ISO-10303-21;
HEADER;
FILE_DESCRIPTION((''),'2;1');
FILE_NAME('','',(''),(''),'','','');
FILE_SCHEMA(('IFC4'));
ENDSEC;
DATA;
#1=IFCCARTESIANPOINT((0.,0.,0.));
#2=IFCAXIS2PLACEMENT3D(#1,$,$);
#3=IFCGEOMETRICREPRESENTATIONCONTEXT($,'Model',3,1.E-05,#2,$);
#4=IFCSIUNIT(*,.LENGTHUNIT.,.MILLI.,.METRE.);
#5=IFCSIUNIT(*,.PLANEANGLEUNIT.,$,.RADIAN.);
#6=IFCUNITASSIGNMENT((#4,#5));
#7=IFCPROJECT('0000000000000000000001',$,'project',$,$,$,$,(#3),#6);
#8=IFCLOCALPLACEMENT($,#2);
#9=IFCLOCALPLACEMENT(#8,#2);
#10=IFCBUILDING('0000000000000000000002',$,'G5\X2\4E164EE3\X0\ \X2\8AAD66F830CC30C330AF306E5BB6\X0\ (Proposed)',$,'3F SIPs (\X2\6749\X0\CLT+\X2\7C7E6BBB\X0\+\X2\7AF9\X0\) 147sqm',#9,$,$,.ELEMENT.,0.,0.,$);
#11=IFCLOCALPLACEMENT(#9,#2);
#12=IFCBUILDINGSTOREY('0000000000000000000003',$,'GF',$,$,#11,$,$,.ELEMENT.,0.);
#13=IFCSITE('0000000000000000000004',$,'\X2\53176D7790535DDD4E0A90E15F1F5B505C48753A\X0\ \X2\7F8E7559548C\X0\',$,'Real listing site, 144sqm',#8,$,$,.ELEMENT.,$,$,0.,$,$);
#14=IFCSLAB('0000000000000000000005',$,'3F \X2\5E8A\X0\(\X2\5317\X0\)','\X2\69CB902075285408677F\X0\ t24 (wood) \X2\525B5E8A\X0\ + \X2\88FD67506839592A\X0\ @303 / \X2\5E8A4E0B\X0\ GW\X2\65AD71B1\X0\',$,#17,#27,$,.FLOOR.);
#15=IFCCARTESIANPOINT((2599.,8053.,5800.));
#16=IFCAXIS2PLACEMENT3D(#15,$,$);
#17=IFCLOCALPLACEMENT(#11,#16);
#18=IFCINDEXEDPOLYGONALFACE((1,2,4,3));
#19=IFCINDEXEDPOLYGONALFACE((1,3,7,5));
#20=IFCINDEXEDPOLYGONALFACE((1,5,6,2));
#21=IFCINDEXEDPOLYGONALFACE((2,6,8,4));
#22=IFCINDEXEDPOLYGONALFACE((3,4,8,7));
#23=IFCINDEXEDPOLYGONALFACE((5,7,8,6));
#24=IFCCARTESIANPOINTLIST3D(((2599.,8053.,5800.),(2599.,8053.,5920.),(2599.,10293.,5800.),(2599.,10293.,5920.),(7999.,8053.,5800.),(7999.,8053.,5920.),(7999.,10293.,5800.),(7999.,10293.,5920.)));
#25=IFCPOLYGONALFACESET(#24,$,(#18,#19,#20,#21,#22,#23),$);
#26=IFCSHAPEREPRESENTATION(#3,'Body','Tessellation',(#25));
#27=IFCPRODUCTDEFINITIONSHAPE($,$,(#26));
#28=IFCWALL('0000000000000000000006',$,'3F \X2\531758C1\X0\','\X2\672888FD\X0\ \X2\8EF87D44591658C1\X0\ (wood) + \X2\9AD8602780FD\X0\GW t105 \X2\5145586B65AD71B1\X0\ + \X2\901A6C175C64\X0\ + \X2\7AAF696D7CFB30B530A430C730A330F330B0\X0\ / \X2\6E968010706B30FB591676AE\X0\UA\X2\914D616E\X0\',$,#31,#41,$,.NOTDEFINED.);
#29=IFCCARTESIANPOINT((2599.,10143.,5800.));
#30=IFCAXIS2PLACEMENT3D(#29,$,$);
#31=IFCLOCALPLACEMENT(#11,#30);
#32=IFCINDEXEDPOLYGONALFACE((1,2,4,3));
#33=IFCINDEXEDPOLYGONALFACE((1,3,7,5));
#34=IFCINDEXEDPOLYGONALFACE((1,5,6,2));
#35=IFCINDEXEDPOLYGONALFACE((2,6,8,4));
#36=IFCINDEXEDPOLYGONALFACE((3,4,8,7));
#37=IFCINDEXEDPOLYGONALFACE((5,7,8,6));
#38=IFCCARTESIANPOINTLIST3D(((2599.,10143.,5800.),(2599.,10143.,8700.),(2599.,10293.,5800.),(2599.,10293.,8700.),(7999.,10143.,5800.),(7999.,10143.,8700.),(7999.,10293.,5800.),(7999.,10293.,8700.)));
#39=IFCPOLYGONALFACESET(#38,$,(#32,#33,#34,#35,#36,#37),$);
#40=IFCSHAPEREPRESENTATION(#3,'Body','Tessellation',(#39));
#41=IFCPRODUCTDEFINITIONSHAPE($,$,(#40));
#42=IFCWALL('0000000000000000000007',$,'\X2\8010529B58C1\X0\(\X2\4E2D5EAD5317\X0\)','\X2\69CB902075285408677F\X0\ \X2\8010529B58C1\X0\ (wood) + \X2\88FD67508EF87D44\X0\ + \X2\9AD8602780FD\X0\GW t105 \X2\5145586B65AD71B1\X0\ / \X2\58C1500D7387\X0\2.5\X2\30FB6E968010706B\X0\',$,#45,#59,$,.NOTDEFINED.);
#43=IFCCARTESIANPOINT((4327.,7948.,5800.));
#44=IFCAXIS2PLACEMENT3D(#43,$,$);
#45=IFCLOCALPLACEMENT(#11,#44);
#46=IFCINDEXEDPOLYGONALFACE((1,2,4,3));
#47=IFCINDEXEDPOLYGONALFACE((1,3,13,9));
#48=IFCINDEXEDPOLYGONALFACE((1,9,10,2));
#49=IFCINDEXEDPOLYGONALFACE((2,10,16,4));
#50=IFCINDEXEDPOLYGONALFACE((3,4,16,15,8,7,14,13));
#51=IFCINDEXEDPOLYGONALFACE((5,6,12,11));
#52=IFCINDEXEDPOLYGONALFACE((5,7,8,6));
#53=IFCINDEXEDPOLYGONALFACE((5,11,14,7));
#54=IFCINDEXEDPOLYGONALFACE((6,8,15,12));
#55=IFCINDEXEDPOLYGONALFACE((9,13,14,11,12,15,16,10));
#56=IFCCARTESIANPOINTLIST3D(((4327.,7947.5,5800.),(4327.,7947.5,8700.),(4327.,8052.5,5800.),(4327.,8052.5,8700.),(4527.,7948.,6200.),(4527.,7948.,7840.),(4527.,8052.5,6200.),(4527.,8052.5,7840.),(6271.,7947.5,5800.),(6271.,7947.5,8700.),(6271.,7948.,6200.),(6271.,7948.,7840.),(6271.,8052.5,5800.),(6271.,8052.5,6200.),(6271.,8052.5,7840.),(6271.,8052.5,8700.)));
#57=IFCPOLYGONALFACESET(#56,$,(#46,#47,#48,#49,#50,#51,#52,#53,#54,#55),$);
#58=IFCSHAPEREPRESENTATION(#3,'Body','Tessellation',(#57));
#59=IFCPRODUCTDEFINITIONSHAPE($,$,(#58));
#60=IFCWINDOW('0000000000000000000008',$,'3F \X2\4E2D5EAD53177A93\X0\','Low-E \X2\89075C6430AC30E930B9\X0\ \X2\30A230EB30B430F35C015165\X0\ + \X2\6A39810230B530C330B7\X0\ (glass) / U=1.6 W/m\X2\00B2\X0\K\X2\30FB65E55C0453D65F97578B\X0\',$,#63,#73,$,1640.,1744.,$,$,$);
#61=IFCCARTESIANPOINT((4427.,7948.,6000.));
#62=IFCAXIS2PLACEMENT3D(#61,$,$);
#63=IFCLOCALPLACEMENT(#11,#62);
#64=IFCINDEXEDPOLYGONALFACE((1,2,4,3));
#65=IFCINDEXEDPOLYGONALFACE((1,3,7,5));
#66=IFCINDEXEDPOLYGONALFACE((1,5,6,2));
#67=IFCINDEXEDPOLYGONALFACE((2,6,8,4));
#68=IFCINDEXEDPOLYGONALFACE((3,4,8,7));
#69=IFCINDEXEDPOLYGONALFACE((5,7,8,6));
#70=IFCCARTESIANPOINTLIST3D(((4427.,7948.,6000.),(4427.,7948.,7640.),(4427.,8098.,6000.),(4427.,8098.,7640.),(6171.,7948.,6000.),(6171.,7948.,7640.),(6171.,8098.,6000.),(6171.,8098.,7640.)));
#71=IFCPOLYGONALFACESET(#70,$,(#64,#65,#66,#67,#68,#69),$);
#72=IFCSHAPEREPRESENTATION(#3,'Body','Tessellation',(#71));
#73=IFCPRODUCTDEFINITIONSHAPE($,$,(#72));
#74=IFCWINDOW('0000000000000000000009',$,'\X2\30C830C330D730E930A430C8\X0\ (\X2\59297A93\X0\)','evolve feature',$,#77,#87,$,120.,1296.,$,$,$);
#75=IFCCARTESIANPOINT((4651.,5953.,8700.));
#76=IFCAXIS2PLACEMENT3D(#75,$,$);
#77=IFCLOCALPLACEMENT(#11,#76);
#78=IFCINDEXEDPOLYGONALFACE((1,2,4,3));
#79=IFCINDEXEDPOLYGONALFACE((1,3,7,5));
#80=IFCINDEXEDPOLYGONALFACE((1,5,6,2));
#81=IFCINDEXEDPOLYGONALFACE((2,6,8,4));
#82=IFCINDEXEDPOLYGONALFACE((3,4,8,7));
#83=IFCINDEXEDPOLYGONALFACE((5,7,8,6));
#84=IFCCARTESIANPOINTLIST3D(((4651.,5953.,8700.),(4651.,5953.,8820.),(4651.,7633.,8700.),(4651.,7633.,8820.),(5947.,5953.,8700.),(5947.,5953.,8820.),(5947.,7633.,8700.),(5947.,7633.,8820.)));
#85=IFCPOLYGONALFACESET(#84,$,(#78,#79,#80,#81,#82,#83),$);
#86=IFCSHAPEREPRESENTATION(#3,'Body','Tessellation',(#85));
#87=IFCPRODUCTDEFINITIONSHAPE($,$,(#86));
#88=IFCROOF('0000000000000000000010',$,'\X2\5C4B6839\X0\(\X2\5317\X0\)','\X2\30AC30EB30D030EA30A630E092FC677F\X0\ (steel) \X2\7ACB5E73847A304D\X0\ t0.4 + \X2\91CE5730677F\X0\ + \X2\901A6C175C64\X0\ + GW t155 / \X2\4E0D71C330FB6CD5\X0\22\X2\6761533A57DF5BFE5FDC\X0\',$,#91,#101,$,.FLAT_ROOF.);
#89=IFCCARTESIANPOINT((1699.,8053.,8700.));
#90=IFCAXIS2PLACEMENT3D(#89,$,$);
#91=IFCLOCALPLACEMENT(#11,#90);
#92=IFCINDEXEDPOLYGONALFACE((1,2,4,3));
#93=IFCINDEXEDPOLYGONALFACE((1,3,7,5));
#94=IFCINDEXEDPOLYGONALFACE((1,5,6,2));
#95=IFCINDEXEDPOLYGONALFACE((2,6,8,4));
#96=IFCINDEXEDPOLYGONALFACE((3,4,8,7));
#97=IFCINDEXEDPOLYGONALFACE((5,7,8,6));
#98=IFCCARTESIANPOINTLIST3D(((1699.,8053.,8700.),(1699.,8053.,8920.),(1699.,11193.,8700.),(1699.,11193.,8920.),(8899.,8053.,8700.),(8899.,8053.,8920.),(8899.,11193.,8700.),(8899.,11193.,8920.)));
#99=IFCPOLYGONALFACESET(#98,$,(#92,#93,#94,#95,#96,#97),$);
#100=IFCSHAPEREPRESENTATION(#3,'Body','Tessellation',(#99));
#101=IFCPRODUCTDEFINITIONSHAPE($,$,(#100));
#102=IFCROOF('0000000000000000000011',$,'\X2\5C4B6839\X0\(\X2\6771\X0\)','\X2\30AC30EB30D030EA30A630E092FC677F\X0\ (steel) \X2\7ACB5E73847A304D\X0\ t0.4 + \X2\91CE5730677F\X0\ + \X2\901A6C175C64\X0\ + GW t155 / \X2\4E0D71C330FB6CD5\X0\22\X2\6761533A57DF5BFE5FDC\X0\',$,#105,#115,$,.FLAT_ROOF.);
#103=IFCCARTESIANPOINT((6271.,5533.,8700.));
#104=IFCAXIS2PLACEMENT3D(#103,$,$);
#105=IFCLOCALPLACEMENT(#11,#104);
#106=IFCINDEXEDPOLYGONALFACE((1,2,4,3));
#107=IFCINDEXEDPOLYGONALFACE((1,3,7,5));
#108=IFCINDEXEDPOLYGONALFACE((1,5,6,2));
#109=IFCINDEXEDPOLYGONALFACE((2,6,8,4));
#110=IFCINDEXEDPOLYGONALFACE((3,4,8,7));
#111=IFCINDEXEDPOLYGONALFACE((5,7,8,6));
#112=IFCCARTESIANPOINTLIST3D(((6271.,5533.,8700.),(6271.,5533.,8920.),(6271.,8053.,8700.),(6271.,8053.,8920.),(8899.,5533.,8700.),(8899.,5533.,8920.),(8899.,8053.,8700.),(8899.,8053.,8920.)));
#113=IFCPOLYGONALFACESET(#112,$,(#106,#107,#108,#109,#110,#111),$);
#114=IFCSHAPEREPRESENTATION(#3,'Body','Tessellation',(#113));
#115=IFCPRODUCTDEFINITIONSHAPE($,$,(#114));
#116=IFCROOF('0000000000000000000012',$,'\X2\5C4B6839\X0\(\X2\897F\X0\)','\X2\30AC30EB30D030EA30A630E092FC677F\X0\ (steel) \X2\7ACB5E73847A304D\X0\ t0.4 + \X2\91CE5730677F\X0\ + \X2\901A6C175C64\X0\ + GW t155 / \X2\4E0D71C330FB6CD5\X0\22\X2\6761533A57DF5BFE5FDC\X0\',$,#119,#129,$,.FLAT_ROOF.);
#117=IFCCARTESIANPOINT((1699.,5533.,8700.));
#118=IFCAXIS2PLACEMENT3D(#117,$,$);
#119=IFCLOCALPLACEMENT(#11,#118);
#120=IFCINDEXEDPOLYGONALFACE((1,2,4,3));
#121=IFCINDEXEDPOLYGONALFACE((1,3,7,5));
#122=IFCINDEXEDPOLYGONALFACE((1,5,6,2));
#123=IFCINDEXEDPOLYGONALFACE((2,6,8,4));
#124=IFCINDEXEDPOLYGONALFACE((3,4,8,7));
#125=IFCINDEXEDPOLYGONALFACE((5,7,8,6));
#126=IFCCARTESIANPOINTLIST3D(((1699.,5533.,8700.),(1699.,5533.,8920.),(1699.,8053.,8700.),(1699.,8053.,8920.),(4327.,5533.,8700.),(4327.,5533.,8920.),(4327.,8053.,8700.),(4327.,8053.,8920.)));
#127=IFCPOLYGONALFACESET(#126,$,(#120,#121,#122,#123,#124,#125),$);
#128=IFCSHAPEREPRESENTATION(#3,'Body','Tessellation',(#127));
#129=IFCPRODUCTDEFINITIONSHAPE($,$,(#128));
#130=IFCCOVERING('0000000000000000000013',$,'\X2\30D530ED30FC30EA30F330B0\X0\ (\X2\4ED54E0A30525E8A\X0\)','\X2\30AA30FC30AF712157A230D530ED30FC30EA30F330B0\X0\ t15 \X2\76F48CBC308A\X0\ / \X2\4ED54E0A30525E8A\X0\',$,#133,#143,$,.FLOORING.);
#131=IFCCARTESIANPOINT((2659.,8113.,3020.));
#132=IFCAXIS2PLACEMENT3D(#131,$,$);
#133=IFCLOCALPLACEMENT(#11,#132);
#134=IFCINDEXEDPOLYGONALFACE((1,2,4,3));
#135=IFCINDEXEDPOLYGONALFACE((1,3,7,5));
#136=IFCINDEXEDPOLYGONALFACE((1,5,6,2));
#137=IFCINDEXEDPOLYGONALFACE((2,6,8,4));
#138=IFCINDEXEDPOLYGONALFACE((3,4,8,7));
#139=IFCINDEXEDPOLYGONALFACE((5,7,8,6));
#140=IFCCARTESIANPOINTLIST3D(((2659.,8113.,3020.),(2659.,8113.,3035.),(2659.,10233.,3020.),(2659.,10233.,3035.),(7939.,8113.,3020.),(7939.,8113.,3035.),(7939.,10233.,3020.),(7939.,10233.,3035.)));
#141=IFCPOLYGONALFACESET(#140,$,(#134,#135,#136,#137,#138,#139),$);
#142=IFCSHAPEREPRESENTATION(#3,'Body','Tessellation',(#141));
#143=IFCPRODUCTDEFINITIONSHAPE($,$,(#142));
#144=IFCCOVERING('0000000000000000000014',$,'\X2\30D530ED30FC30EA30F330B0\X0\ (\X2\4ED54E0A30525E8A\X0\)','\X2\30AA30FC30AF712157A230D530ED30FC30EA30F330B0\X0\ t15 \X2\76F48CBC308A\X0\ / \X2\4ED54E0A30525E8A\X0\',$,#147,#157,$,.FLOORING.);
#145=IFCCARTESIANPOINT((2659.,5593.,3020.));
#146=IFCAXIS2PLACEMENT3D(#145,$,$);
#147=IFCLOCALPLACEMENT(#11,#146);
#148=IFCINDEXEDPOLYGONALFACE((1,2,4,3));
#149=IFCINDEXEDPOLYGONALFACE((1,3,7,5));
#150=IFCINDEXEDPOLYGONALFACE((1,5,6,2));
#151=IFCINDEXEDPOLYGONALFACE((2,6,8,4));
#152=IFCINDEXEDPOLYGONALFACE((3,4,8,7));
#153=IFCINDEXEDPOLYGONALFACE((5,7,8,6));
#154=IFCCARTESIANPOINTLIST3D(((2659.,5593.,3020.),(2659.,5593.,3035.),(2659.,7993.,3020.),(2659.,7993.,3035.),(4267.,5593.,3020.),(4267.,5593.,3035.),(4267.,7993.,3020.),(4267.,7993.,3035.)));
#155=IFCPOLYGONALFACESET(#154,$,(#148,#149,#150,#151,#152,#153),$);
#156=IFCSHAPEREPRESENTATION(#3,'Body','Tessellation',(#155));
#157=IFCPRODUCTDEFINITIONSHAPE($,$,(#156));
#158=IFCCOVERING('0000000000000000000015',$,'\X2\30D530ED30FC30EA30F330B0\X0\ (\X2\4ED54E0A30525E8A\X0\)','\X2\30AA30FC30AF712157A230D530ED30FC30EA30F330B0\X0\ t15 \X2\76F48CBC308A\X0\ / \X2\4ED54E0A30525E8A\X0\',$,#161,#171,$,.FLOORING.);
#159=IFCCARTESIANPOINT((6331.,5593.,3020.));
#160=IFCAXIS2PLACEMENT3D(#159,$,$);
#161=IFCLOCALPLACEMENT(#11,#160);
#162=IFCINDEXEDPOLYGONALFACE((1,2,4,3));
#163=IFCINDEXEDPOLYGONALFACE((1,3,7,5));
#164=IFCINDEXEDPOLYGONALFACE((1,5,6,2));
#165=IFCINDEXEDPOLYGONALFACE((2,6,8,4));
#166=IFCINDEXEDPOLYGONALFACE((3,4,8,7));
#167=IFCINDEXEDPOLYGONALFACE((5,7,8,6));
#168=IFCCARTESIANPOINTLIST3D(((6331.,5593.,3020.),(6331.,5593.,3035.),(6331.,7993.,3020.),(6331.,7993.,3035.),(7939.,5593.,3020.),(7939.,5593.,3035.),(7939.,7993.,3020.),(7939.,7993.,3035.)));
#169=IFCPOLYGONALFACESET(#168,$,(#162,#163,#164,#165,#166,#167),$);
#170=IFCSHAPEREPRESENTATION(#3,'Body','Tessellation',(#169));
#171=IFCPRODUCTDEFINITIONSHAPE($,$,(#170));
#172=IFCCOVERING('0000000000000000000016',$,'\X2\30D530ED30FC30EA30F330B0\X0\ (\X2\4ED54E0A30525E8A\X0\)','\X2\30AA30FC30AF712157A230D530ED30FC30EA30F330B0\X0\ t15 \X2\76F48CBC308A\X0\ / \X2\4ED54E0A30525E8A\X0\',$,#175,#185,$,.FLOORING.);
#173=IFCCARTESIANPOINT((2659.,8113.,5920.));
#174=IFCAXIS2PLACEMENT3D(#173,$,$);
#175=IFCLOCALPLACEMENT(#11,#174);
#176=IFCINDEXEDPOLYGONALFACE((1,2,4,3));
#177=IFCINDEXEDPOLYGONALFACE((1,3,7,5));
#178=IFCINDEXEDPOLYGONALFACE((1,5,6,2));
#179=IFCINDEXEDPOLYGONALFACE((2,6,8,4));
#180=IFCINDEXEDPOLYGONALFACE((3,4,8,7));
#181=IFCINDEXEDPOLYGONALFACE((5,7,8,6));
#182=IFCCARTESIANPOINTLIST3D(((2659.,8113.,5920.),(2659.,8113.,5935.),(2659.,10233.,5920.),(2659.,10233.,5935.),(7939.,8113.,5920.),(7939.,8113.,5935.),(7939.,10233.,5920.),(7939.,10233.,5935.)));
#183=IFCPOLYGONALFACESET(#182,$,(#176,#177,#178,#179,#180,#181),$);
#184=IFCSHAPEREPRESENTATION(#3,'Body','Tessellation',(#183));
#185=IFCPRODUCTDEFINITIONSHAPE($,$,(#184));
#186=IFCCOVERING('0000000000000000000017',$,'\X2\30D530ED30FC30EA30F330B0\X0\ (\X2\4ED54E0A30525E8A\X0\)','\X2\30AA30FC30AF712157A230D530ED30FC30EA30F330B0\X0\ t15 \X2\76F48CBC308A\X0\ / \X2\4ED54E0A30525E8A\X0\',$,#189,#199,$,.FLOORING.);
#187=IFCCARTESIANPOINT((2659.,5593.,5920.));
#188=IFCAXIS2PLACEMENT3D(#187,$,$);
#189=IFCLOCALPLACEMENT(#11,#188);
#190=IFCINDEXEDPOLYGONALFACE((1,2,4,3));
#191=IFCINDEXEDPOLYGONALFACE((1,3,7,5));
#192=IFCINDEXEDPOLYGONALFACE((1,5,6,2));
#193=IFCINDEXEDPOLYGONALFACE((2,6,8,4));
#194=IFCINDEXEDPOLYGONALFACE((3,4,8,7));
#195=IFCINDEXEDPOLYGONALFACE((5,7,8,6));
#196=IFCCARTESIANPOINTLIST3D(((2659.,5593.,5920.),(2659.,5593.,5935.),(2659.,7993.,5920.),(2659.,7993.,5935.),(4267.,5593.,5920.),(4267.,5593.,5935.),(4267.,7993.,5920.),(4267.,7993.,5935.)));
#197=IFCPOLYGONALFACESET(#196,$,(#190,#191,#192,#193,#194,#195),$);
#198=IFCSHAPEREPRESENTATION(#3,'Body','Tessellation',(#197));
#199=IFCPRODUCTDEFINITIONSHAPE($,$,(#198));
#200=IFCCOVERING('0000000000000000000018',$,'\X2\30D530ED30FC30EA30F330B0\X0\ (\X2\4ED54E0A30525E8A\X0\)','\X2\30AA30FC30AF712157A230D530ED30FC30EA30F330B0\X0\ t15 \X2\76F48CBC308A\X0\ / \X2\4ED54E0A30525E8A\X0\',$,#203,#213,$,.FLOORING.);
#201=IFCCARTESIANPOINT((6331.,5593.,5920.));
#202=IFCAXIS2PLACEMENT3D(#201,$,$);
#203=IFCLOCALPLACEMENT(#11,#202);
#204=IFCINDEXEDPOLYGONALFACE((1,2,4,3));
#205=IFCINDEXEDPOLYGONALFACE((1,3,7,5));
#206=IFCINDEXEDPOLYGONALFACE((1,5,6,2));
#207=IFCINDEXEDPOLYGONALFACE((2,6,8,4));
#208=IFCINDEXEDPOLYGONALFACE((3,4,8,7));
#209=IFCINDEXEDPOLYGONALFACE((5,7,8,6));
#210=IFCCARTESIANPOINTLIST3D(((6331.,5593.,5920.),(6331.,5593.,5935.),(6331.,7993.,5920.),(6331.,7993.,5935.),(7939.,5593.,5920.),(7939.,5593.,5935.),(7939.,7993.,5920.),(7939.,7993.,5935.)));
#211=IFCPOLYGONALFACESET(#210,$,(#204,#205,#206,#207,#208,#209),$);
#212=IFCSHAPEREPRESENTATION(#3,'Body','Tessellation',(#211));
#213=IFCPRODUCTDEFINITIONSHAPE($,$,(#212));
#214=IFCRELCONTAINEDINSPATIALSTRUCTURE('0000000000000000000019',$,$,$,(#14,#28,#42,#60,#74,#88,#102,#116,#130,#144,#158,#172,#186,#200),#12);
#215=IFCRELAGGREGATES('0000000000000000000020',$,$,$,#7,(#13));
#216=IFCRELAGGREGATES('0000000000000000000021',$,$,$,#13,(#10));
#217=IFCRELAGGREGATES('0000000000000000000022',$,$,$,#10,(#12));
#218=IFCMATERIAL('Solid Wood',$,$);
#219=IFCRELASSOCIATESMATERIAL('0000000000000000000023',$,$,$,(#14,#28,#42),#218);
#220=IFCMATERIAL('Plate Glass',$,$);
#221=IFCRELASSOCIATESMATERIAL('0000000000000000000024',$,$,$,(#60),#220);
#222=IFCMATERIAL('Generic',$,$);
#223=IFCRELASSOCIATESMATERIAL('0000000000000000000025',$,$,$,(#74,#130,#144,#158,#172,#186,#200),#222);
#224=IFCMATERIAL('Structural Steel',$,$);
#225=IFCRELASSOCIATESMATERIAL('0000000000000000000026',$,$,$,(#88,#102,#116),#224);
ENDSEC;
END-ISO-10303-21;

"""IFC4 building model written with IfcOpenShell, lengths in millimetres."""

from ifc_helpers import new_model, si_unit, frame, frame_2d, origin, place, context, project, spatial, rectangle, extrude, material, element, fill, save


model = new_model("IFC4")

# Units and contexts
model_context = context("Model", 3, precision=1e-05, world=origin())
ifc_project = project(units=[si_unit("LENGTHUNIT", "METRE", prefix="MILLI"), si_unit("PLANEANGLEUNIT", "RADIAN")], contexts=[model_context])

# Site, building, storey
site_placement = place(None, origin())
site = spatial("IfcSite", under=ifc_project, at=site_placement, Name="北海道川上郡弟子屈町 美留和", ObjectType="Real listing site, 144sqm", CompositionType="ELEMENT", RefElevation=0.0)
building_placement = place(site_placement, origin())
building = spatial("IfcBuilding", under=site, at=building_placement, Name="G5世代 読書ヌックの家 (Proposed)", ObjectType="3F SIPs (杉CLT+籾殻+竹) 147sqm", CompositionType="ELEMENT", ElevationOfRefHeight=0.0, ElevationOfTerrain=0.0)
storey_placement = place(building_placement, origin())
storey = spatial("IfcBuildingStorey", under=building, at=storey_placement, Name="GF", CompositionType="ELEMENT", Elevation=0.0)

# Slab
ifc_material_1 = material(Name="Solid Wood")
slab_placement = place(storey_placement, frame((2599.0, 8053.0, 5800.0)))
element("IfcSlab", 1, at=slab_placement, inside=storey, material=ifc_material_1, Name="3F 床(北)", Description="構造用合板 t24 (wood) 剛床 + 製材根太 @303 / 床下 GW断熱", PredefinedType="FLOOR", context=model_context, shape_type="SweptSolid", body=[
    extrude(rectangle(XDim=5400.0, YDim=2240.0, at=frame_2d((2700.0, 1120.0))), frame((2599.0, 8053.0, 5800.0)), (0.0, 0.0, 1.0), 120.0),
])

# Wall
wall_1_placement = place(storey_placement, frame((2599.0, 10143.0, 5800.0)))
element("IfcWall", 2, at=wall_1_placement, inside=storey, material=ifc_material_1, Name="3F 北壁", Description="木製 軸組外壁 (wood) + 高性能GW t105 充填断熱 + 通気層 + 窯業系サイディング / 準耐火・外皮UA配慮", PredefinedType="NOTDEFINED", context=model_context, shape_type="SweptSolid", body=[
    extrude(rectangle(XDim=5400.0, YDim=150.0, at=frame_2d((2700.0, 75.0))), frame((2599.0, 10143.0, 5800.0)), (0.0, 0.0, 1.0), 2900.0),
])

# Wall, opening, window
wall_2_placement = place(storey_placement, frame((4327.0, 7948.0, 5800.0)))
wall_2 = element("IfcWall", 3, at=wall_2_placement, inside=storey, material=ifc_material_1, Name="耐力壁(中庭北)", Description="構造用合板 耐力壁 (wood) + 製材軸組 + 高性能GW t105 充填断熱 / 壁倍率2.5・準耐火", PredefinedType="NOTDEFINED", context=model_context, shape_type="SweptSolid", body=[
    extrude(rectangle(XDim=1944.0, YDim=105.0, at=frame_2d((972.0, 52.0))), frame((4327.0, 7948.0, 5800.0)), (0.0, 0.0, 1.0), 2900.0),
])
opening_placement = place(storey_placement, frame((4427.0, 7948.0, 6000.0)))
opening = element("IfcOpeningElement", 4, at=opening_placement, cuts=wall_2, PredefinedType="NOTDEFINED", context=model_context, shape_type="SweptSolid", body=[
    extrude(rectangle(XDim=1744.0, YDim=150.0, at=frame_2d((872.0, 75.0))), frame((4427.0, 7948.0, 6000.0)), (0.0, 0.0, 1.0), 1640.0),
])
ifc_material_2 = material(Name="Plate Glass")
window_1_placement = place(storey_placement, frame((4427.0, 7948.0, 6000.0)))
window_1 = element("IfcWindow", 5, at=window_1_placement, inside=storey, material=ifc_material_2, Name="3F 中庭北窓", Description="Low-E 複層ガラス アルゴン封入 + 樹脂サッシ (glass) / U=1.6 W/m²K・日射取得型", OverallHeight=1640.0, OverallWidth=1744.0, context=model_context, shape_type="SweptSolid", body=[
    extrude(rectangle(XDim=1744.0, YDim=150.0, at=frame_2d((872.0, 75.0))), frame((4427.0, 7948.0, 6000.0)), (0.0, 0.0, 1.0), 1640.0),
])
fill(opening, window_1)

# Window
ifc_material_3 = material(Name="Generic")
window_2_placement = place(storey_placement, frame((4651.0, 5953.0, 8700.0)))
element("IfcWindow", 6, at=window_2_placement, inside=storey, material=ifc_material_3, Name="トップライト (天窓)", Description="evolve feature", OverallHeight=120.0, OverallWidth=1296.0, context=model_context, shape_type="SweptSolid", body=[
    extrude(rectangle(XDim=1296.0, YDim=1680.0, at=frame_2d((648.0, 840.0))), frame((4651.0, 5953.0, 8700.0)), (0.0, 0.0, 1.0), 120.0),
])

# Roofs
ifc_material_4 = material(Name="Structural Steel")
roof_1_placement = place(storey_placement, frame((1699.0, 8053.0, 8700.0)))
element("IfcRoof", 7, at=roof_1_placement, inside=storey, material=ifc_material_4, Name="屋根(北)", Description="ガルバリウム鋼板 (steel) 立平葺き t0.4 + 野地板 + 通気層 + GW t155 / 不燃・法22条区域対応", PredefinedType="FLAT_ROOF", context=model_context, shape_type="SweptSolid", body=[
    extrude(rectangle(XDim=7200.0, YDim=3140.0, at=frame_2d((3600.0, 1570.0))), frame((1699.0, 8053.0, 8700.0)), (0.0, 0.0, 1.0), 220.0),
])
roof_2_placement = place(storey_placement, frame((6271.0, 5533.0, 8700.0)))
element("IfcRoof", 8, at=roof_2_placement, inside=storey, material=ifc_material_4, Name="屋根(東)", Description="ガルバリウム鋼板 (steel) 立平葺き t0.4 + 野地板 + 通気層 + GW t155 / 不燃・法22条区域対応", PredefinedType="FLAT_ROOF", context=model_context, shape_type="SweptSolid", body=[
    extrude(rectangle(XDim=2628.0, YDim=2520.0, at=frame_2d((1314.0, 1260.0))), frame((6271.0, 5533.0, 8700.0)), (0.0, 0.0, 1.0), 220.0),
])
roof_3_placement = place(storey_placement, frame((1699.0, 5533.0, 8700.0)))
element("IfcRoof", 9, at=roof_3_placement, inside=storey, material=ifc_material_4, Name="屋根(西)", Description="ガルバリウム鋼板 (steel) 立平葺き t0.4 + 野地板 + 通気層 + GW t155 / 不燃・法22条区域対応", PredefinedType="FLAT_ROOF", context=model_context, shape_type="SweptSolid", body=[
    extrude(rectangle(XDim=2628.0, YDim=2520.0, at=frame_2d((1314.0, 1260.0))), frame((1699.0, 5533.0, 8700.0)), (0.0, 0.0, 1.0), 220.0),
])

# Coverings
covering_1_placement = place(storey_placement, frame((2659.0, 8113.0, 3020.0)))
element("IfcCovering", 10, at=covering_1_placement, inside=storey, material=ifc_material_3, Name="フローリング (仕上げ床)", Description="オーク無垢フローリング t15 直貼り / 仕上げ床", PredefinedType="FLOORING", context=model_context, shape_type="SweptSolid", body=[
    extrude(rectangle(XDim=5280.0, YDim=2120.0, at=frame_2d((2640.0, 1060.0))), frame((2659.0, 8113.0, 3020.0)), (0.0, 0.0, 1.0), 15.0),
])
covering_2_placement = place(storey_placement, frame((2659.0, 5593.0, 3020.0)))
element("IfcCovering", 11, at=covering_2_placement, inside=storey, material=ifc_material_3, Name="フローリング (仕上げ床)", Description="オーク無垢フローリング t15 直貼り / 仕上げ床", PredefinedType="FLOORING", context=model_context, shape_type="SweptSolid", body=[
    extrude(rectangle(XDim=1608.0, YDim=2400.0, at=frame_2d((804.0, 1200.0))), frame((2659.0, 5593.0, 3020.0)), (0.0, 0.0, 1.0), 15.0),
])
covering_3_placement = place(storey_placement, frame((6331.0, 5593.0, 3020.0)))
element("IfcCovering", 12, at=covering_3_placement, inside=storey, material=ifc_material_3, Name="フローリング (仕上げ床)", Description="オーク無垢フローリング t15 直貼り / 仕上げ床", PredefinedType="FLOORING", context=model_context, shape_type="SweptSolid", body=[
    extrude(rectangle(XDim=1608.0, YDim=2400.0, at=frame_2d((804.0, 1200.0))), frame((6331.0, 5593.0, 3020.0)), (0.0, 0.0, 1.0), 15.0),
])
covering_4_placement = place(storey_placement, frame((2659.0, 8113.0, 5920.0)))
element("IfcCovering", 13, at=covering_4_placement, inside=storey, material=ifc_material_3, Name="フローリング (仕上げ床)", Description="オーク無垢フローリング t15 直貼り / 仕上げ床", PredefinedType="FLOORING", context=model_context, shape_type="SweptSolid", body=[
    extrude(rectangle(XDim=5280.0, YDim=2120.0, at=frame_2d((2640.0, 1060.0))), frame((2659.0, 8113.0, 5920.0)), (0.0, 0.0, 1.0), 15.0),
])
covering_5_placement = place(storey_placement, frame((2659.0, 5593.0, 5920.0)))
element("IfcCovering", 14, at=covering_5_placement, inside=storey, material=ifc_material_3, Name="フローリング (仕上げ床)", Description="オーク無垢フローリング t15 直貼り / 仕上げ床", PredefinedType="FLOORING", context=model_context, shape_type="SweptSolid", body=[
    extrude(rectangle(XDim=1608.0, YDim=2400.0, at=frame_2d((804.0, 1200.0))), frame((2659.0, 5593.0, 5920.0)), (0.0, 0.0, 1.0), 15.0),
])
covering_6_placement = place(storey_placement, frame((6331.0, 5593.0, 5920.0)))
element("IfcCovering", 15, at=covering_6_placement, inside=storey, material=ifc_material_3, Name="フローリング (仕上げ床)", Description="オーク無垢フローリング t15 直貼り / 仕上げ床", PredefinedType="FLOORING", context=model_context, shape_type="SweptSolid", body=[
    extrude(rectangle(XDim=1608.0, YDim=2400.0, at=frame_2d((804.0, 1200.0))), frame((6331.0, 5593.0, 5920.0)), (0.0, 0.0, 1.0), 15.0),
])

save(model, "model.ifc")
